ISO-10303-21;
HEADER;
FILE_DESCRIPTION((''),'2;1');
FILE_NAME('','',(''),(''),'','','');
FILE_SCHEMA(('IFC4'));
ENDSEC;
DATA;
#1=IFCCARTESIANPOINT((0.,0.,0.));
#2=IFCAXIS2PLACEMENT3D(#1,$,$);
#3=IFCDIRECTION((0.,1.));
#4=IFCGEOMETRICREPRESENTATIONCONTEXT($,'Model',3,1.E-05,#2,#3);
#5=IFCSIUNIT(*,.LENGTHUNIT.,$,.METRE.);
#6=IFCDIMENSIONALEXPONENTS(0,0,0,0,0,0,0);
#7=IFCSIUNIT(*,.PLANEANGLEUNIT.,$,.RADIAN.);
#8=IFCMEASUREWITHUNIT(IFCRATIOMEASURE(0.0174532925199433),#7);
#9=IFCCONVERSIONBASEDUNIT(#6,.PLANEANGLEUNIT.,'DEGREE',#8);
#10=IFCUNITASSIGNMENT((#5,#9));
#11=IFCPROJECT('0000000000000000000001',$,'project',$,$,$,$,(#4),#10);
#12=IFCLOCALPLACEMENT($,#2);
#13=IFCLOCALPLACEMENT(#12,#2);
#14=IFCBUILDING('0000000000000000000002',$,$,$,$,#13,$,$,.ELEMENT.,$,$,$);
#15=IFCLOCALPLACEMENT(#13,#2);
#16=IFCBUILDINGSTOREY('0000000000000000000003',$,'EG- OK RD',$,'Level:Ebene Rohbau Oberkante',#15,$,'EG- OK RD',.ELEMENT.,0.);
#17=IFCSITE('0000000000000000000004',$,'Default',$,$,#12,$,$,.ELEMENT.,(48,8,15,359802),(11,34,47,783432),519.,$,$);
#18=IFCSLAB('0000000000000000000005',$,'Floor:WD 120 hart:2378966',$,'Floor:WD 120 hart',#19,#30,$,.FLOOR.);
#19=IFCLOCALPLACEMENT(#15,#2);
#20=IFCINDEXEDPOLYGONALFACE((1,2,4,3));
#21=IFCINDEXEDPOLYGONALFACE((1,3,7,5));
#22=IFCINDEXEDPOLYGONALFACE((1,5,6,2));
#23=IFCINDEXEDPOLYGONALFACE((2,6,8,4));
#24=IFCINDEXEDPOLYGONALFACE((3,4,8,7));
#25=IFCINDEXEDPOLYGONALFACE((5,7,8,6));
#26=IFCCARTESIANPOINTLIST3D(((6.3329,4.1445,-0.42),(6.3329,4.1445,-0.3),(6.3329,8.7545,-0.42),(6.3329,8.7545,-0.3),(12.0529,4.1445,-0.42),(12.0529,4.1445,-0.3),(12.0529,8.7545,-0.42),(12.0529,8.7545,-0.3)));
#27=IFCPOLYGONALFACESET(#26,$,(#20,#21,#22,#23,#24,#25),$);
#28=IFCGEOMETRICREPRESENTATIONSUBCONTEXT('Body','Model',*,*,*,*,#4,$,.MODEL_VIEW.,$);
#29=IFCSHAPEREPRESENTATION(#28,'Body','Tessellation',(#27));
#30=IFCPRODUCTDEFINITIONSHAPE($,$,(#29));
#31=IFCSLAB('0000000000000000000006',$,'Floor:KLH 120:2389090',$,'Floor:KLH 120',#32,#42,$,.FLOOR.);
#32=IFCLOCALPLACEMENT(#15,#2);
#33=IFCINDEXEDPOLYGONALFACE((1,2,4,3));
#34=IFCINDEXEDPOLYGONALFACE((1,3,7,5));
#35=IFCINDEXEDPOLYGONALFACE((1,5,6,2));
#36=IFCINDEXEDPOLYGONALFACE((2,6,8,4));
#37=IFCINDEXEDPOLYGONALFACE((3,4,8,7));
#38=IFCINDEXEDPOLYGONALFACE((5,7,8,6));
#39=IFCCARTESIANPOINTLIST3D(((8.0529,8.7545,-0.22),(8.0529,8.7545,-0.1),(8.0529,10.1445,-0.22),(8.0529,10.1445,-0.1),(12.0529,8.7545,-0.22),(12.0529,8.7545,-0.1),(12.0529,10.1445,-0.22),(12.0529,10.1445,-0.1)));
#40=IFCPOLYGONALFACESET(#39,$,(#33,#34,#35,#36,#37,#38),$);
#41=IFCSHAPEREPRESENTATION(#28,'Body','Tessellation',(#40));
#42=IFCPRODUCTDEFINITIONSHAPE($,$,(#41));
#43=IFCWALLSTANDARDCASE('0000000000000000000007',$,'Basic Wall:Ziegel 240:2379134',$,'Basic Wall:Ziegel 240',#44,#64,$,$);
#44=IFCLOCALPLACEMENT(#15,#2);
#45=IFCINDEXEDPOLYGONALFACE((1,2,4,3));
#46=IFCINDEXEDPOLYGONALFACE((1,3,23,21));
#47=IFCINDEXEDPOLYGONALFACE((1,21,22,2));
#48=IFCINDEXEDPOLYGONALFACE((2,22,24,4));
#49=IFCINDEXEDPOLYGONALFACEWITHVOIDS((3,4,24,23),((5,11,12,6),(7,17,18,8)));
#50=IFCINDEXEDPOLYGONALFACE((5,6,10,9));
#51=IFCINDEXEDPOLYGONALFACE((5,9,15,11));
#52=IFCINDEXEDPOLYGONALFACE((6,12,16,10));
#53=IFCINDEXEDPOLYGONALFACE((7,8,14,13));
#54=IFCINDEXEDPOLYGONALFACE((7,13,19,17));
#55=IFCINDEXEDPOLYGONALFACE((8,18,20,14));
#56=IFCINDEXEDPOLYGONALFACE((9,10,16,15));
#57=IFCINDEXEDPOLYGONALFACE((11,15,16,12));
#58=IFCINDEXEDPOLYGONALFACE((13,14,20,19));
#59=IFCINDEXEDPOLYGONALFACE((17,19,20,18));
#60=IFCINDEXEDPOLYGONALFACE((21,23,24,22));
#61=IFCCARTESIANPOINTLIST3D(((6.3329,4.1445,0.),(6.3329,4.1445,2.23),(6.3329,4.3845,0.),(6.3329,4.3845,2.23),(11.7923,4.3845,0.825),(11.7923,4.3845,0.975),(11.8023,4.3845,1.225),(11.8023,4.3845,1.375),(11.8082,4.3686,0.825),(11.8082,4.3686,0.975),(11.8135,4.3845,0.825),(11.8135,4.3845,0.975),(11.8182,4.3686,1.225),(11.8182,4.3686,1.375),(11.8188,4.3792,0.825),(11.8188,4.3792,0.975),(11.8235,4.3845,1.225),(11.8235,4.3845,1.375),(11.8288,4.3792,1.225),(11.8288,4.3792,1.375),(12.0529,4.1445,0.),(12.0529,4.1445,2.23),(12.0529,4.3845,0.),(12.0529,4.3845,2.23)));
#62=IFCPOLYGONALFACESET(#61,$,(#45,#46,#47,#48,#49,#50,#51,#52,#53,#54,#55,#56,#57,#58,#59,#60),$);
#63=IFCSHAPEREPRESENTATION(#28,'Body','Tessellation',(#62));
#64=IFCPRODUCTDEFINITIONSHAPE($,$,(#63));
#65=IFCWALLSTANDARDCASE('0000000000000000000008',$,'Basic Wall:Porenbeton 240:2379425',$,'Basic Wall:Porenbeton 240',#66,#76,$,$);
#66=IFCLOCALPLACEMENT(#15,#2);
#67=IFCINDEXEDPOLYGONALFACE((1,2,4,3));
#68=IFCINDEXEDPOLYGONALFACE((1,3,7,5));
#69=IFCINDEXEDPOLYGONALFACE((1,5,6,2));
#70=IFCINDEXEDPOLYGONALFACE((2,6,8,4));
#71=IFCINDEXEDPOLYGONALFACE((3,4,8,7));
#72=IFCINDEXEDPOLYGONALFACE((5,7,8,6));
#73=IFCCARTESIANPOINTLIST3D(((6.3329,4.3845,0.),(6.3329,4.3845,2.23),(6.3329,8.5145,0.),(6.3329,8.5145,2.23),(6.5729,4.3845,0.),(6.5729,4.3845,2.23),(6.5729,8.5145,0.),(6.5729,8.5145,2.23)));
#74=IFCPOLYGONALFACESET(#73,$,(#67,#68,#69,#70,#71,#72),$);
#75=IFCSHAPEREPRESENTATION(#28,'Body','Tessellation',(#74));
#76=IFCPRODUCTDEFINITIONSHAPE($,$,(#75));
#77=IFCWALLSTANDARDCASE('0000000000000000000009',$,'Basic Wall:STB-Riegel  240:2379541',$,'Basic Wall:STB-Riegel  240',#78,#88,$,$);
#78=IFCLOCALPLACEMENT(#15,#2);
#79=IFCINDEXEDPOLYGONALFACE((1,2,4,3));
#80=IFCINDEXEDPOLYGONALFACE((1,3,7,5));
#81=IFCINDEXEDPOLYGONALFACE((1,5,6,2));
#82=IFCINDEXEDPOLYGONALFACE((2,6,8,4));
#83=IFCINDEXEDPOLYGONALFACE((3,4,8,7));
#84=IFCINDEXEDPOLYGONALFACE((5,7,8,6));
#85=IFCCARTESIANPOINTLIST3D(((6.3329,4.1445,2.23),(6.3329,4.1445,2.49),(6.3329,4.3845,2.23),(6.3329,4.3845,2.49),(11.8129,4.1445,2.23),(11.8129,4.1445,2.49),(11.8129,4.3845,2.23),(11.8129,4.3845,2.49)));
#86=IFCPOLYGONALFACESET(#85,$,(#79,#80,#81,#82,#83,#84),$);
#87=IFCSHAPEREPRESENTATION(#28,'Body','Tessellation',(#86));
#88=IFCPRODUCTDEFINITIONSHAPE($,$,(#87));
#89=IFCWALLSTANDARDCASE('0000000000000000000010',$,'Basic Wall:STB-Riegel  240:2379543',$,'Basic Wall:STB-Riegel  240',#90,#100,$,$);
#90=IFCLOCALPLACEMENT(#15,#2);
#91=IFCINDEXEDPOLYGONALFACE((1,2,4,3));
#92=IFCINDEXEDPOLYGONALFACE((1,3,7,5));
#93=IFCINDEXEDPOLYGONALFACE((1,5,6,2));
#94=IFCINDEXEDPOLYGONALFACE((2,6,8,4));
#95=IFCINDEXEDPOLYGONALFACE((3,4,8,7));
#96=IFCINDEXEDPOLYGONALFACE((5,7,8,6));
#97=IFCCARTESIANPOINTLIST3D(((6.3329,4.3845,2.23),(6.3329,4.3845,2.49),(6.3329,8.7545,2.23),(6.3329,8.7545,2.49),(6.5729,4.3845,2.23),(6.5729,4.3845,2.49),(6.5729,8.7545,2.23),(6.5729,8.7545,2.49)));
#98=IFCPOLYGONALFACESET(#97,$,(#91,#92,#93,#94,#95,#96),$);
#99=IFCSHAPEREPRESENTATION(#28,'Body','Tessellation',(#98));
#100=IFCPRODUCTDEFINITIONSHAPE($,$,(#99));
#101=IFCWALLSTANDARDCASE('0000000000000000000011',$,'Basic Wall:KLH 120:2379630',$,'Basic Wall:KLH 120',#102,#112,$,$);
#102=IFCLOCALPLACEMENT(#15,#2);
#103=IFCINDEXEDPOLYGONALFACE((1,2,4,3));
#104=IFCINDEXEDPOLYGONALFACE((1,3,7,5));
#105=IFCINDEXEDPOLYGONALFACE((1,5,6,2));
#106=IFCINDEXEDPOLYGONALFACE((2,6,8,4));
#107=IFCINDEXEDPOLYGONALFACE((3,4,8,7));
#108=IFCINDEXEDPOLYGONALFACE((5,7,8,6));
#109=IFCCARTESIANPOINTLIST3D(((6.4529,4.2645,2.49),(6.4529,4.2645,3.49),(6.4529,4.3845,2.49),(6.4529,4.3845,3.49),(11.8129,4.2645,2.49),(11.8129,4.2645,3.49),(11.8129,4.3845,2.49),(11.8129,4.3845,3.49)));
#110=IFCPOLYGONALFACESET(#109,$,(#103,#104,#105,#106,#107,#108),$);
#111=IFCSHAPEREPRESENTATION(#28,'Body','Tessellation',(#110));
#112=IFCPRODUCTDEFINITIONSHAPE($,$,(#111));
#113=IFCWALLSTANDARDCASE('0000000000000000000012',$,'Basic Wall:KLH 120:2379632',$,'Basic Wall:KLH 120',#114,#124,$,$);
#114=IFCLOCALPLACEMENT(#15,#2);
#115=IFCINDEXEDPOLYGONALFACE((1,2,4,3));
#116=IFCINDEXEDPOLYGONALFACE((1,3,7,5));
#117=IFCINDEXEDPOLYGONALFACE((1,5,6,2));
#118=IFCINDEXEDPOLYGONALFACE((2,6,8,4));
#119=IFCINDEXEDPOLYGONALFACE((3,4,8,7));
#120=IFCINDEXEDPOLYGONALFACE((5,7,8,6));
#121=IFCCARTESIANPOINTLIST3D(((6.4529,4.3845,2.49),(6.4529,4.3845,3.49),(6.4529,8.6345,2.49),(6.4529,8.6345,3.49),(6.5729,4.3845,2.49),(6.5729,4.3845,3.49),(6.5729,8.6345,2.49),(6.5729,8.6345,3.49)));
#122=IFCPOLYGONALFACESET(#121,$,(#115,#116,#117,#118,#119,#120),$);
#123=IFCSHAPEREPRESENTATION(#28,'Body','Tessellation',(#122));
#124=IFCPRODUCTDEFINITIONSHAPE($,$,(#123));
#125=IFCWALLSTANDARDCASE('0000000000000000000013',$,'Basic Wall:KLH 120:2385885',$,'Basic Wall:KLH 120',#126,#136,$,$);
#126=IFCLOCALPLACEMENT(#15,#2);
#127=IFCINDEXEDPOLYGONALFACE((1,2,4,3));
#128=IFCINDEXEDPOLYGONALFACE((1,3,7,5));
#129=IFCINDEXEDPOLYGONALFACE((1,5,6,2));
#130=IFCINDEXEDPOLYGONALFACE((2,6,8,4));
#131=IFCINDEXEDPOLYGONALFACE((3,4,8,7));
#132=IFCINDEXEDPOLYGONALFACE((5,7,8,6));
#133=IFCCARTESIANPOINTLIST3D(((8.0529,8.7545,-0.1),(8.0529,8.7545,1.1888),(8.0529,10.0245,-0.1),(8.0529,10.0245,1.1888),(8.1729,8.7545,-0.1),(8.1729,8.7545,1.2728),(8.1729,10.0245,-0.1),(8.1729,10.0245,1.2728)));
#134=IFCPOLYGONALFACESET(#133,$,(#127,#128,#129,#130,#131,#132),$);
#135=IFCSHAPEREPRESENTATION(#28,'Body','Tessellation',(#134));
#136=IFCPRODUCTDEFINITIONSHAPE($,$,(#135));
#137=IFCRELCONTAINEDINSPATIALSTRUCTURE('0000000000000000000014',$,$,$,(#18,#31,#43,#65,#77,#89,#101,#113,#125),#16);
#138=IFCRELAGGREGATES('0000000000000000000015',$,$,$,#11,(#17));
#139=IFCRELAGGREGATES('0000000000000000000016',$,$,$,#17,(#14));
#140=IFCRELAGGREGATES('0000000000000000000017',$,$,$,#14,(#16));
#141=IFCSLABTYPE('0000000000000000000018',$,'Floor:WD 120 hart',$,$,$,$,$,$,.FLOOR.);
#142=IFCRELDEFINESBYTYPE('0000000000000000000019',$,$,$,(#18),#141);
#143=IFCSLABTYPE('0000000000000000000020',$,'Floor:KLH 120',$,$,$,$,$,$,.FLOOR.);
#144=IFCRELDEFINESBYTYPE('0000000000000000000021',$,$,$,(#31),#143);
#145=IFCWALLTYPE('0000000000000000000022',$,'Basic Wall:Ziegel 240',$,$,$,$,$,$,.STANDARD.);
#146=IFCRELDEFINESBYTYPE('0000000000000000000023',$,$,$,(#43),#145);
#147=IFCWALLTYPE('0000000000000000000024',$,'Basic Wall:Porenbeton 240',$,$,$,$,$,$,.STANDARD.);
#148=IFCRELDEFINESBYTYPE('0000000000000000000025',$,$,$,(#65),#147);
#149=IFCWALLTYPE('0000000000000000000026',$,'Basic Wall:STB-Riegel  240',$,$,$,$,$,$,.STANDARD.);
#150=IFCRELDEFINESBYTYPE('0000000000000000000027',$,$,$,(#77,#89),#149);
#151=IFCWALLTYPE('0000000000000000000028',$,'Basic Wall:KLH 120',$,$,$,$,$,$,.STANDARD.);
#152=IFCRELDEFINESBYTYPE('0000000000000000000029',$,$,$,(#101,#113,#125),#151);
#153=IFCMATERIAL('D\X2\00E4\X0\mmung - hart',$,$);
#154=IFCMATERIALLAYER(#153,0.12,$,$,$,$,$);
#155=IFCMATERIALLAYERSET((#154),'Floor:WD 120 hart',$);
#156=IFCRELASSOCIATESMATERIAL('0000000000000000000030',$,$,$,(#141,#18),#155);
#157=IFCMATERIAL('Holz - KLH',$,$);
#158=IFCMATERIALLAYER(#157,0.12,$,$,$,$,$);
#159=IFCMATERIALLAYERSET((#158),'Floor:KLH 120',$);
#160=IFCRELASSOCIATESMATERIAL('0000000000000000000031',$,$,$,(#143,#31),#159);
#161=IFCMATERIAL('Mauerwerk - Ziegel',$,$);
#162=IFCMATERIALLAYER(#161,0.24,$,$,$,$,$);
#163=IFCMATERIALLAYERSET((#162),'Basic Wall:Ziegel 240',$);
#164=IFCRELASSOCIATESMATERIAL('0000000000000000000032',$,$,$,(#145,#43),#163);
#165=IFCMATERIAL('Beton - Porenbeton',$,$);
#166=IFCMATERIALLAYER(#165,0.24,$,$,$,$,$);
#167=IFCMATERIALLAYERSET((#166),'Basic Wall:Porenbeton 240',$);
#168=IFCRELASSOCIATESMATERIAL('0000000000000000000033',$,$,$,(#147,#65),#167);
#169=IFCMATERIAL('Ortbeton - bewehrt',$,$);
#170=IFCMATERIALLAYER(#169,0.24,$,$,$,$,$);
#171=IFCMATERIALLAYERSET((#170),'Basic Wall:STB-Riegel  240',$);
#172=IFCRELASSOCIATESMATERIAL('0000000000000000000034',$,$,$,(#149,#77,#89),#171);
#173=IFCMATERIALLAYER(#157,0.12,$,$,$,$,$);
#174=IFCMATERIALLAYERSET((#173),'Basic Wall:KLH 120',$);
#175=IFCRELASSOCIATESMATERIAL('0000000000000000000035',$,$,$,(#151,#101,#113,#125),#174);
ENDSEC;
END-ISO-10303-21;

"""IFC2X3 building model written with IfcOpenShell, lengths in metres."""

from ifc_helpers import new_model, entity, si_unit, converted_unit, direction, frame, frame_2d, origin, place, context, subcontext, project, spatial, polyline, rectangle, extrude, clip, bounded_halfspace, material, layer, layer_set, layer_usage, type_object, element, save


model = new_model("IFC2X3")

# Units and contexts
model_context = context("Model", 3, precision=1e-05, world=origin(), true_north=direction((0.0, 1.0)))
body_context = subcontext(model_context, "Body", "Model", "MODEL_VIEW")
ifc_project = project(units=[si_unit("LENGTHUNIT", "METRE"), converted_unit("PLANEANGLEUNIT", "DEGREE", entity("IfcRatioMeasure", 0.0174532925199433), si_unit("PLANEANGLEUNIT", "RADIAN"), dimensions=[0, 0, 0, 0, 0, 0, 0])], contexts=[model_context])

# Site, building, storey
site_placement = place(None, origin())
site = spatial("IfcSite", under=ifc_project, at=site_placement, Name="Default", CompositionType="ELEMENT", RefLatitude=(48, 8, 15, 359802), RefLongitude=(11, 34, 47, 783432), RefElevation=519.0)
building_placement = place(site_placement, origin())
building = spatial("IfcBuilding", under=site, at=building_placement, CompositionType="ELEMENT")
storey_placement = place(building_placement, origin())
storey = spatial("IfcBuildingStorey", under=building, at=storey_placement, Name="EG- OK RD", ObjectType="Level:Ebene Rohbau Oberkante", LongName="EG- OK RD", CompositionType="ELEMENT", Elevation=0.0)

# Shared definitions
ifc_material_1 = material(Name="Ortbeton - bewehrt")

# Slabs
ifc_material_2 = material(Name="Dämmung - hart")
ifc_layer_1 = layer(ifc_material_2, 0.12)
ifc_layer_set_1 = layer_set([ifc_layer_1], Name="Floor:WD 120 hart")
ifc_layer_usage_1 = layer_usage(ifc_layer_set_1, "AXIS3", "POSITIVE", 0.0)
slab_type_1 = type_object("IfcSlabType", Name="Floor:WD 120 hart", PredefinedType="FLOOR", material=ifc_layer_set_1)
slab_1_placement = place(storey_placement, origin())
element("IfcSlab", 1, at=slab_1_placement, inside=storey, type_object=slab_type_1, material=ifc_layer_usage_1, Name="Floor:WD 120 hart:2378966", ObjectType="Floor:WD 120 hart", PredefinedType="FLOOR", context=body_context, shape_type="SweptSolid", body=[
    extrude(rectangle(XDim=4.61, YDim=5.72, at=frame_2d((0.0, 0.0), x_axis=(1.0, 0.0))), frame((9.1929, 6.4495, -0.3), z_axis=(0.0, 0.0, -1.0), x_axis=(0.0, 1.0, 0.0)), (0.0, 0.0, 1.0), 0.12),
])
ifc_material_3 = material(Name="Holz - KLH")
ifc_layer_2 = layer(ifc_material_3, 0.12)
ifc_layer_set_2 = layer_set([ifc_layer_2], Name="Floor:KLH 120")
ifc_layer_usage_2 = layer_usage(ifc_layer_set_2, "AXIS3", "POSITIVE", 0.0)
slab_type_2 = type_object("IfcSlabType", Name="Floor:KLH 120", PredefinedType="FLOOR", material=ifc_layer_set_2)
slab_2_placement = place(storey_placement, origin())
element("IfcSlab", 2, at=slab_2_placement, inside=storey, type_object=slab_type_2, material=ifc_layer_usage_2, Name="Floor:KLH 120:2389090", ObjectType="Floor:KLH 120", PredefinedType="FLOOR", context=body_context, shape_type="SweptSolid", body=[
    extrude(rectangle(XDim=1.39, YDim=4.0, at=frame_2d((0.0, 0.0), x_axis=(1.0, 0.0))), frame((10.0529, 9.4495, -0.1), z_axis=(0.0, 0.0, -1.0), x_axis=(0.0, 1.0, 0.0)), (0.0, 0.0, 1.0), 0.12),
])

# Wall, openings
ifc_material_4 = material(Name="Mauerwerk - Ziegel")
ifc_layer_3 = layer(ifc_material_4, 0.24)
ifc_layer_set_3 = layer_set([ifc_layer_3], Name="Basic Wall:Ziegel 240")
ifc_layer_usage_3 = layer_usage(ifc_layer_set_3, "AXIS2", "POSITIVE", -0.12)
wall_type_1 = type_object("IfcWallType", Name="Basic Wall:Ziegel 240", PredefinedType="STANDARD", material=ifc_layer_set_3)
wall_1_placement = place(storey_placement, frame((6.3329, 4.2645, 0.0)))
wall_1 = element("IfcWallStandardCase", 3, at=wall_1_placement, inside=storey, type_object=wall_type_1, material=ifc_layer_usage_3, Name="Basic Wall:Ziegel 240:2379134", ObjectType="Basic Wall:Ziegel 240", context=body_context, shape_type="SweptSolid", body=[
    extrude(rectangle(XDim=5.72, YDim=0.24, at=frame_2d((2.86, 0.0), x_axis=(-1.0, 0.0))), origin(), (0.0, 0.0, 1.0), 2.23),
])
opening_1_placement = place(wall_1_placement, origin())
element("IfcOpeningElement", 4, at=opening_1_placement, cuts=wall_1, ObjectType="Recess", context=body_context, shape_type="SweptSolid", body=[
    extrude(rectangle(XDim=0.15, YDim=0.0285, at=frame_2d((0.0, 0.0), x_axis=(0.0, 1.0))), frame((5.3605, 0.2289, 1.1), z_axis=(0.707107, 0.707107, 0.0), x_axis=(0.707107, -0.707107, 0.0)), (0.0, 0.0, 1.0), 0.015),
])
opening_2_placement = place(wall_1_placement, origin())
element("IfcOpeningElement", 5, at=opening_2_placement, cuts=wall_1, ObjectType="Recess", context=body_context, shape_type="SweptSolid", body=[
    extrude(rectangle(XDim=0.15, YDim=0.0285, at=frame_2d((0.0, 0.0), x_axis=(0.0, 1.0))), frame((5.4652, 0.1142, 0.9), z_axis=(0.707107, 0.707107, 0.0), x_axis=(0.707107, -0.707107, 0.0)), (0.0, 0.0, 1.0), 0.015),
])
opening_3_placement = place(wall_1_placement, origin())
element("IfcOpeningElement", 6, at=opening_3_placement, cuts=wall_1, ObjectType="Recess", context=body_context, shape_type="SweptSolid", body=[
    extrude(rectangle(XDim=0.15, YDim=0.0285, at=frame_2d((0.0, 0.0), x_axis=(0.0, 1.0))), frame((5.4752, 0.1142, 1.3), z_axis=(0.707107, 0.707107, 0.0), x_axis=(0.707107, -0.707107, 0.0)), (0.0, 0.0, 1.0), 0.015),
])

# Walls
ifc_material_5 = material(Name="Beton - Porenbeton")
ifc_layer_4 = layer(ifc_material_5, 0.24)
ifc_layer_set_4 = layer_set([ifc_layer_4], Name="Basic Wall:Porenbeton 240")
ifc_layer_usage_4 = layer_usage(ifc_layer_set_4, "AXIS2", "POSITIVE", -0.12)
wall_type_2 = type_object("IfcWallType", Name="Basic Wall:Porenbeton 240", PredefinedType="STANDARD", material=ifc_layer_set_4)
wall_2_placement = place(storey_placement, frame((6.4529, 8.5145, 0.0), z_axis=(0.0, 0.0, 1.0), x_axis=(0.0, -1.0, 0.0)))
element("IfcWallStandardCase", 7, at=wall_2_placement, inside=storey, type_object=wall_type_2, material=ifc_layer_usage_4, Name="Basic Wall:Porenbeton 240:2379425", ObjectType="Basic Wall:Porenbeton 240", context=body_context, shape_type="SweptSolid", body=[
    extrude(rectangle(XDim=4.13, YDim=0.24, at=frame_2d((2.065, 0.0), x_axis=(-1.0, 0.0))), origin(), (0.0, 0.0, 1.0), 2.23),
])
ifc_layer_5 = layer(ifc_material_1, 0.24)
ifc_layer_set_5 = layer_set([ifc_layer_5], Name="Basic Wall:STB-Riegel  240")
ifc_layer_usage_5 = layer_usage(ifc_layer_set_5, "AXIS2", "NEGATIVE", 0.12)
wall_type_3 = type_object("IfcWallType", Name="Basic Wall:STB-Riegel  240", PredefinedType="STANDARD", material=ifc_layer_set_5)
wall_3_placement = place(storey_placement, frame((6.3329, 4.2645, 2.23)))
element("IfcWallStandardCase", 8, at=wall_3_placement, inside=storey, type_object=wall_type_3, material=ifc_layer_usage_5, Name="Basic Wall:STB-Riegel  240:2379541", ObjectType="Basic Wall:STB-Riegel  240", context=body_context, shape_type="SweptSolid", body=[
    extrude(rectangle(XDim=5.48, YDim=0.24, at=frame_2d((2.74, 0.0), x_axis=(-1.0, 0.0))), origin(), (0.0, 0.0, 1.0), 0.26),
])
ifc_layer_usage_6 = layer_usage(ifc_layer_set_5, "AXIS2", "NEGATIVE", 0.12)
wall_4_placement = place(storey_placement, frame((6.4529, 8.7545, 2.23), z_axis=(0.0, 0.0, 1.0), x_axis=(0.0, -1.0, 0.0)))
element("IfcWallStandardCase", 9, at=wall_4_placement, inside=storey, type_object=wall_type_3, material=ifc_layer_usage_6, Name="Basic Wall:STB-Riegel  240:2379543", ObjectType="Basic Wall:STB-Riegel  240", context=body_context, shape_type="SweptSolid", body=[
    extrude(rectangle(XDim=4.37, YDim=0.24, at=frame_2d((2.185, 0.0), x_axis=(-1.0, 0.0))), origin(), (0.0, 0.0, 1.0), 0.26),
])
ifc_layer_6 = layer(ifc_material_3, 0.12)
ifc_layer_set_6 = layer_set([ifc_layer_6], Name="Basic Wall:KLH 120")
ifc_layer_usage_7 = layer_usage(ifc_layer_set_6, "AXIS2", "NEGATIVE", 0.06)
wall_type_4 = type_object("IfcWallType", Name="Basic Wall:KLH 120", PredefinedType="STANDARD", material=ifc_layer_set_6)
wall_5_placement = place(storey_placement, frame((6.4529, 4.3245, 2.49)))
element("IfcWallStandardCase", 10, at=wall_5_placement, inside=storey, type_object=wall_type_4, material=ifc_layer_usage_7, Name="Basic Wall:KLH 120:2379630", ObjectType="Basic Wall:KLH 120", context=body_context, shape_type="SweptSolid", body=[
    extrude(rectangle(XDim=5.36, YDim=0.12, at=frame_2d((2.68, 0.0), x_axis=(-1.0, 0.0))), origin(), (0.0, 0.0, 1.0), 1.0),
])
ifc_layer_usage_8 = layer_usage(ifc_layer_set_6, "AXIS2", "NEGATIVE", 0.06)
wall_6_placement = place(storey_placement, frame((6.5129, 8.6345, 2.49), z_axis=(0.0, 0.0, 1.0), x_axis=(0.0, -1.0, 0.0)))
element("IfcWallStandardCase", 11, at=wall_6_placement, inside=storey, type_object=wall_type_4, material=ifc_layer_usage_8, Name="Basic Wall:KLH 120:2379632", ObjectType="Basic Wall:KLH 120", context=body_context, shape_type="SweptSolid", body=[
    extrude(rectangle(XDim=4.25, YDim=0.12, at=frame_2d((2.125, 0.0), x_axis=(-1.0, 0.0))), origin(), (0.0, 0.0, 1.0), 1.0),
])
ifc_layer_usage_9 = layer_usage(ifc_layer_set_6, "AXIS2", "NEGATIVE", 0.06)
wall_7_placement = place(storey_placement, frame((8.1129, 8.7545, -0.1), z_axis=(0.0, 0.0, 1.0), x_axis=(0.0, 1.0, 0.0)))
element("IfcWallStandardCase", 12, at=wall_7_placement, inside=storey, type_object=wall_type_4, material=ifc_layer_usage_9, Name="Basic Wall:KLH 120:2385885", ObjectType="Basic Wall:KLH 120", context=body_context, shape_type="Clipping", body=[
    clip(extrude(rectangle(XDim=1.27, YDim=0.12, at=frame_2d((0.635, 0.0), x_axis=(-1.0, 0.0))), origin(), (0.0, 0.0, 1.0), 1.3728), bounded_halfspace(frame((0.0, -0.06, 1.3728), z_axis=(0.0, -0.573576, -0.819152), x_axis=(-1.0, 0.0, 0.0)), True, frame((0.0, -0.06, 1.3728)), polyline([(0.0, 0.0), (1.27, 0.0), (1.27, 0.12), (0.0, 0.12), (0.0, 0.0)]))),
])

save(model, "model.ifc")
